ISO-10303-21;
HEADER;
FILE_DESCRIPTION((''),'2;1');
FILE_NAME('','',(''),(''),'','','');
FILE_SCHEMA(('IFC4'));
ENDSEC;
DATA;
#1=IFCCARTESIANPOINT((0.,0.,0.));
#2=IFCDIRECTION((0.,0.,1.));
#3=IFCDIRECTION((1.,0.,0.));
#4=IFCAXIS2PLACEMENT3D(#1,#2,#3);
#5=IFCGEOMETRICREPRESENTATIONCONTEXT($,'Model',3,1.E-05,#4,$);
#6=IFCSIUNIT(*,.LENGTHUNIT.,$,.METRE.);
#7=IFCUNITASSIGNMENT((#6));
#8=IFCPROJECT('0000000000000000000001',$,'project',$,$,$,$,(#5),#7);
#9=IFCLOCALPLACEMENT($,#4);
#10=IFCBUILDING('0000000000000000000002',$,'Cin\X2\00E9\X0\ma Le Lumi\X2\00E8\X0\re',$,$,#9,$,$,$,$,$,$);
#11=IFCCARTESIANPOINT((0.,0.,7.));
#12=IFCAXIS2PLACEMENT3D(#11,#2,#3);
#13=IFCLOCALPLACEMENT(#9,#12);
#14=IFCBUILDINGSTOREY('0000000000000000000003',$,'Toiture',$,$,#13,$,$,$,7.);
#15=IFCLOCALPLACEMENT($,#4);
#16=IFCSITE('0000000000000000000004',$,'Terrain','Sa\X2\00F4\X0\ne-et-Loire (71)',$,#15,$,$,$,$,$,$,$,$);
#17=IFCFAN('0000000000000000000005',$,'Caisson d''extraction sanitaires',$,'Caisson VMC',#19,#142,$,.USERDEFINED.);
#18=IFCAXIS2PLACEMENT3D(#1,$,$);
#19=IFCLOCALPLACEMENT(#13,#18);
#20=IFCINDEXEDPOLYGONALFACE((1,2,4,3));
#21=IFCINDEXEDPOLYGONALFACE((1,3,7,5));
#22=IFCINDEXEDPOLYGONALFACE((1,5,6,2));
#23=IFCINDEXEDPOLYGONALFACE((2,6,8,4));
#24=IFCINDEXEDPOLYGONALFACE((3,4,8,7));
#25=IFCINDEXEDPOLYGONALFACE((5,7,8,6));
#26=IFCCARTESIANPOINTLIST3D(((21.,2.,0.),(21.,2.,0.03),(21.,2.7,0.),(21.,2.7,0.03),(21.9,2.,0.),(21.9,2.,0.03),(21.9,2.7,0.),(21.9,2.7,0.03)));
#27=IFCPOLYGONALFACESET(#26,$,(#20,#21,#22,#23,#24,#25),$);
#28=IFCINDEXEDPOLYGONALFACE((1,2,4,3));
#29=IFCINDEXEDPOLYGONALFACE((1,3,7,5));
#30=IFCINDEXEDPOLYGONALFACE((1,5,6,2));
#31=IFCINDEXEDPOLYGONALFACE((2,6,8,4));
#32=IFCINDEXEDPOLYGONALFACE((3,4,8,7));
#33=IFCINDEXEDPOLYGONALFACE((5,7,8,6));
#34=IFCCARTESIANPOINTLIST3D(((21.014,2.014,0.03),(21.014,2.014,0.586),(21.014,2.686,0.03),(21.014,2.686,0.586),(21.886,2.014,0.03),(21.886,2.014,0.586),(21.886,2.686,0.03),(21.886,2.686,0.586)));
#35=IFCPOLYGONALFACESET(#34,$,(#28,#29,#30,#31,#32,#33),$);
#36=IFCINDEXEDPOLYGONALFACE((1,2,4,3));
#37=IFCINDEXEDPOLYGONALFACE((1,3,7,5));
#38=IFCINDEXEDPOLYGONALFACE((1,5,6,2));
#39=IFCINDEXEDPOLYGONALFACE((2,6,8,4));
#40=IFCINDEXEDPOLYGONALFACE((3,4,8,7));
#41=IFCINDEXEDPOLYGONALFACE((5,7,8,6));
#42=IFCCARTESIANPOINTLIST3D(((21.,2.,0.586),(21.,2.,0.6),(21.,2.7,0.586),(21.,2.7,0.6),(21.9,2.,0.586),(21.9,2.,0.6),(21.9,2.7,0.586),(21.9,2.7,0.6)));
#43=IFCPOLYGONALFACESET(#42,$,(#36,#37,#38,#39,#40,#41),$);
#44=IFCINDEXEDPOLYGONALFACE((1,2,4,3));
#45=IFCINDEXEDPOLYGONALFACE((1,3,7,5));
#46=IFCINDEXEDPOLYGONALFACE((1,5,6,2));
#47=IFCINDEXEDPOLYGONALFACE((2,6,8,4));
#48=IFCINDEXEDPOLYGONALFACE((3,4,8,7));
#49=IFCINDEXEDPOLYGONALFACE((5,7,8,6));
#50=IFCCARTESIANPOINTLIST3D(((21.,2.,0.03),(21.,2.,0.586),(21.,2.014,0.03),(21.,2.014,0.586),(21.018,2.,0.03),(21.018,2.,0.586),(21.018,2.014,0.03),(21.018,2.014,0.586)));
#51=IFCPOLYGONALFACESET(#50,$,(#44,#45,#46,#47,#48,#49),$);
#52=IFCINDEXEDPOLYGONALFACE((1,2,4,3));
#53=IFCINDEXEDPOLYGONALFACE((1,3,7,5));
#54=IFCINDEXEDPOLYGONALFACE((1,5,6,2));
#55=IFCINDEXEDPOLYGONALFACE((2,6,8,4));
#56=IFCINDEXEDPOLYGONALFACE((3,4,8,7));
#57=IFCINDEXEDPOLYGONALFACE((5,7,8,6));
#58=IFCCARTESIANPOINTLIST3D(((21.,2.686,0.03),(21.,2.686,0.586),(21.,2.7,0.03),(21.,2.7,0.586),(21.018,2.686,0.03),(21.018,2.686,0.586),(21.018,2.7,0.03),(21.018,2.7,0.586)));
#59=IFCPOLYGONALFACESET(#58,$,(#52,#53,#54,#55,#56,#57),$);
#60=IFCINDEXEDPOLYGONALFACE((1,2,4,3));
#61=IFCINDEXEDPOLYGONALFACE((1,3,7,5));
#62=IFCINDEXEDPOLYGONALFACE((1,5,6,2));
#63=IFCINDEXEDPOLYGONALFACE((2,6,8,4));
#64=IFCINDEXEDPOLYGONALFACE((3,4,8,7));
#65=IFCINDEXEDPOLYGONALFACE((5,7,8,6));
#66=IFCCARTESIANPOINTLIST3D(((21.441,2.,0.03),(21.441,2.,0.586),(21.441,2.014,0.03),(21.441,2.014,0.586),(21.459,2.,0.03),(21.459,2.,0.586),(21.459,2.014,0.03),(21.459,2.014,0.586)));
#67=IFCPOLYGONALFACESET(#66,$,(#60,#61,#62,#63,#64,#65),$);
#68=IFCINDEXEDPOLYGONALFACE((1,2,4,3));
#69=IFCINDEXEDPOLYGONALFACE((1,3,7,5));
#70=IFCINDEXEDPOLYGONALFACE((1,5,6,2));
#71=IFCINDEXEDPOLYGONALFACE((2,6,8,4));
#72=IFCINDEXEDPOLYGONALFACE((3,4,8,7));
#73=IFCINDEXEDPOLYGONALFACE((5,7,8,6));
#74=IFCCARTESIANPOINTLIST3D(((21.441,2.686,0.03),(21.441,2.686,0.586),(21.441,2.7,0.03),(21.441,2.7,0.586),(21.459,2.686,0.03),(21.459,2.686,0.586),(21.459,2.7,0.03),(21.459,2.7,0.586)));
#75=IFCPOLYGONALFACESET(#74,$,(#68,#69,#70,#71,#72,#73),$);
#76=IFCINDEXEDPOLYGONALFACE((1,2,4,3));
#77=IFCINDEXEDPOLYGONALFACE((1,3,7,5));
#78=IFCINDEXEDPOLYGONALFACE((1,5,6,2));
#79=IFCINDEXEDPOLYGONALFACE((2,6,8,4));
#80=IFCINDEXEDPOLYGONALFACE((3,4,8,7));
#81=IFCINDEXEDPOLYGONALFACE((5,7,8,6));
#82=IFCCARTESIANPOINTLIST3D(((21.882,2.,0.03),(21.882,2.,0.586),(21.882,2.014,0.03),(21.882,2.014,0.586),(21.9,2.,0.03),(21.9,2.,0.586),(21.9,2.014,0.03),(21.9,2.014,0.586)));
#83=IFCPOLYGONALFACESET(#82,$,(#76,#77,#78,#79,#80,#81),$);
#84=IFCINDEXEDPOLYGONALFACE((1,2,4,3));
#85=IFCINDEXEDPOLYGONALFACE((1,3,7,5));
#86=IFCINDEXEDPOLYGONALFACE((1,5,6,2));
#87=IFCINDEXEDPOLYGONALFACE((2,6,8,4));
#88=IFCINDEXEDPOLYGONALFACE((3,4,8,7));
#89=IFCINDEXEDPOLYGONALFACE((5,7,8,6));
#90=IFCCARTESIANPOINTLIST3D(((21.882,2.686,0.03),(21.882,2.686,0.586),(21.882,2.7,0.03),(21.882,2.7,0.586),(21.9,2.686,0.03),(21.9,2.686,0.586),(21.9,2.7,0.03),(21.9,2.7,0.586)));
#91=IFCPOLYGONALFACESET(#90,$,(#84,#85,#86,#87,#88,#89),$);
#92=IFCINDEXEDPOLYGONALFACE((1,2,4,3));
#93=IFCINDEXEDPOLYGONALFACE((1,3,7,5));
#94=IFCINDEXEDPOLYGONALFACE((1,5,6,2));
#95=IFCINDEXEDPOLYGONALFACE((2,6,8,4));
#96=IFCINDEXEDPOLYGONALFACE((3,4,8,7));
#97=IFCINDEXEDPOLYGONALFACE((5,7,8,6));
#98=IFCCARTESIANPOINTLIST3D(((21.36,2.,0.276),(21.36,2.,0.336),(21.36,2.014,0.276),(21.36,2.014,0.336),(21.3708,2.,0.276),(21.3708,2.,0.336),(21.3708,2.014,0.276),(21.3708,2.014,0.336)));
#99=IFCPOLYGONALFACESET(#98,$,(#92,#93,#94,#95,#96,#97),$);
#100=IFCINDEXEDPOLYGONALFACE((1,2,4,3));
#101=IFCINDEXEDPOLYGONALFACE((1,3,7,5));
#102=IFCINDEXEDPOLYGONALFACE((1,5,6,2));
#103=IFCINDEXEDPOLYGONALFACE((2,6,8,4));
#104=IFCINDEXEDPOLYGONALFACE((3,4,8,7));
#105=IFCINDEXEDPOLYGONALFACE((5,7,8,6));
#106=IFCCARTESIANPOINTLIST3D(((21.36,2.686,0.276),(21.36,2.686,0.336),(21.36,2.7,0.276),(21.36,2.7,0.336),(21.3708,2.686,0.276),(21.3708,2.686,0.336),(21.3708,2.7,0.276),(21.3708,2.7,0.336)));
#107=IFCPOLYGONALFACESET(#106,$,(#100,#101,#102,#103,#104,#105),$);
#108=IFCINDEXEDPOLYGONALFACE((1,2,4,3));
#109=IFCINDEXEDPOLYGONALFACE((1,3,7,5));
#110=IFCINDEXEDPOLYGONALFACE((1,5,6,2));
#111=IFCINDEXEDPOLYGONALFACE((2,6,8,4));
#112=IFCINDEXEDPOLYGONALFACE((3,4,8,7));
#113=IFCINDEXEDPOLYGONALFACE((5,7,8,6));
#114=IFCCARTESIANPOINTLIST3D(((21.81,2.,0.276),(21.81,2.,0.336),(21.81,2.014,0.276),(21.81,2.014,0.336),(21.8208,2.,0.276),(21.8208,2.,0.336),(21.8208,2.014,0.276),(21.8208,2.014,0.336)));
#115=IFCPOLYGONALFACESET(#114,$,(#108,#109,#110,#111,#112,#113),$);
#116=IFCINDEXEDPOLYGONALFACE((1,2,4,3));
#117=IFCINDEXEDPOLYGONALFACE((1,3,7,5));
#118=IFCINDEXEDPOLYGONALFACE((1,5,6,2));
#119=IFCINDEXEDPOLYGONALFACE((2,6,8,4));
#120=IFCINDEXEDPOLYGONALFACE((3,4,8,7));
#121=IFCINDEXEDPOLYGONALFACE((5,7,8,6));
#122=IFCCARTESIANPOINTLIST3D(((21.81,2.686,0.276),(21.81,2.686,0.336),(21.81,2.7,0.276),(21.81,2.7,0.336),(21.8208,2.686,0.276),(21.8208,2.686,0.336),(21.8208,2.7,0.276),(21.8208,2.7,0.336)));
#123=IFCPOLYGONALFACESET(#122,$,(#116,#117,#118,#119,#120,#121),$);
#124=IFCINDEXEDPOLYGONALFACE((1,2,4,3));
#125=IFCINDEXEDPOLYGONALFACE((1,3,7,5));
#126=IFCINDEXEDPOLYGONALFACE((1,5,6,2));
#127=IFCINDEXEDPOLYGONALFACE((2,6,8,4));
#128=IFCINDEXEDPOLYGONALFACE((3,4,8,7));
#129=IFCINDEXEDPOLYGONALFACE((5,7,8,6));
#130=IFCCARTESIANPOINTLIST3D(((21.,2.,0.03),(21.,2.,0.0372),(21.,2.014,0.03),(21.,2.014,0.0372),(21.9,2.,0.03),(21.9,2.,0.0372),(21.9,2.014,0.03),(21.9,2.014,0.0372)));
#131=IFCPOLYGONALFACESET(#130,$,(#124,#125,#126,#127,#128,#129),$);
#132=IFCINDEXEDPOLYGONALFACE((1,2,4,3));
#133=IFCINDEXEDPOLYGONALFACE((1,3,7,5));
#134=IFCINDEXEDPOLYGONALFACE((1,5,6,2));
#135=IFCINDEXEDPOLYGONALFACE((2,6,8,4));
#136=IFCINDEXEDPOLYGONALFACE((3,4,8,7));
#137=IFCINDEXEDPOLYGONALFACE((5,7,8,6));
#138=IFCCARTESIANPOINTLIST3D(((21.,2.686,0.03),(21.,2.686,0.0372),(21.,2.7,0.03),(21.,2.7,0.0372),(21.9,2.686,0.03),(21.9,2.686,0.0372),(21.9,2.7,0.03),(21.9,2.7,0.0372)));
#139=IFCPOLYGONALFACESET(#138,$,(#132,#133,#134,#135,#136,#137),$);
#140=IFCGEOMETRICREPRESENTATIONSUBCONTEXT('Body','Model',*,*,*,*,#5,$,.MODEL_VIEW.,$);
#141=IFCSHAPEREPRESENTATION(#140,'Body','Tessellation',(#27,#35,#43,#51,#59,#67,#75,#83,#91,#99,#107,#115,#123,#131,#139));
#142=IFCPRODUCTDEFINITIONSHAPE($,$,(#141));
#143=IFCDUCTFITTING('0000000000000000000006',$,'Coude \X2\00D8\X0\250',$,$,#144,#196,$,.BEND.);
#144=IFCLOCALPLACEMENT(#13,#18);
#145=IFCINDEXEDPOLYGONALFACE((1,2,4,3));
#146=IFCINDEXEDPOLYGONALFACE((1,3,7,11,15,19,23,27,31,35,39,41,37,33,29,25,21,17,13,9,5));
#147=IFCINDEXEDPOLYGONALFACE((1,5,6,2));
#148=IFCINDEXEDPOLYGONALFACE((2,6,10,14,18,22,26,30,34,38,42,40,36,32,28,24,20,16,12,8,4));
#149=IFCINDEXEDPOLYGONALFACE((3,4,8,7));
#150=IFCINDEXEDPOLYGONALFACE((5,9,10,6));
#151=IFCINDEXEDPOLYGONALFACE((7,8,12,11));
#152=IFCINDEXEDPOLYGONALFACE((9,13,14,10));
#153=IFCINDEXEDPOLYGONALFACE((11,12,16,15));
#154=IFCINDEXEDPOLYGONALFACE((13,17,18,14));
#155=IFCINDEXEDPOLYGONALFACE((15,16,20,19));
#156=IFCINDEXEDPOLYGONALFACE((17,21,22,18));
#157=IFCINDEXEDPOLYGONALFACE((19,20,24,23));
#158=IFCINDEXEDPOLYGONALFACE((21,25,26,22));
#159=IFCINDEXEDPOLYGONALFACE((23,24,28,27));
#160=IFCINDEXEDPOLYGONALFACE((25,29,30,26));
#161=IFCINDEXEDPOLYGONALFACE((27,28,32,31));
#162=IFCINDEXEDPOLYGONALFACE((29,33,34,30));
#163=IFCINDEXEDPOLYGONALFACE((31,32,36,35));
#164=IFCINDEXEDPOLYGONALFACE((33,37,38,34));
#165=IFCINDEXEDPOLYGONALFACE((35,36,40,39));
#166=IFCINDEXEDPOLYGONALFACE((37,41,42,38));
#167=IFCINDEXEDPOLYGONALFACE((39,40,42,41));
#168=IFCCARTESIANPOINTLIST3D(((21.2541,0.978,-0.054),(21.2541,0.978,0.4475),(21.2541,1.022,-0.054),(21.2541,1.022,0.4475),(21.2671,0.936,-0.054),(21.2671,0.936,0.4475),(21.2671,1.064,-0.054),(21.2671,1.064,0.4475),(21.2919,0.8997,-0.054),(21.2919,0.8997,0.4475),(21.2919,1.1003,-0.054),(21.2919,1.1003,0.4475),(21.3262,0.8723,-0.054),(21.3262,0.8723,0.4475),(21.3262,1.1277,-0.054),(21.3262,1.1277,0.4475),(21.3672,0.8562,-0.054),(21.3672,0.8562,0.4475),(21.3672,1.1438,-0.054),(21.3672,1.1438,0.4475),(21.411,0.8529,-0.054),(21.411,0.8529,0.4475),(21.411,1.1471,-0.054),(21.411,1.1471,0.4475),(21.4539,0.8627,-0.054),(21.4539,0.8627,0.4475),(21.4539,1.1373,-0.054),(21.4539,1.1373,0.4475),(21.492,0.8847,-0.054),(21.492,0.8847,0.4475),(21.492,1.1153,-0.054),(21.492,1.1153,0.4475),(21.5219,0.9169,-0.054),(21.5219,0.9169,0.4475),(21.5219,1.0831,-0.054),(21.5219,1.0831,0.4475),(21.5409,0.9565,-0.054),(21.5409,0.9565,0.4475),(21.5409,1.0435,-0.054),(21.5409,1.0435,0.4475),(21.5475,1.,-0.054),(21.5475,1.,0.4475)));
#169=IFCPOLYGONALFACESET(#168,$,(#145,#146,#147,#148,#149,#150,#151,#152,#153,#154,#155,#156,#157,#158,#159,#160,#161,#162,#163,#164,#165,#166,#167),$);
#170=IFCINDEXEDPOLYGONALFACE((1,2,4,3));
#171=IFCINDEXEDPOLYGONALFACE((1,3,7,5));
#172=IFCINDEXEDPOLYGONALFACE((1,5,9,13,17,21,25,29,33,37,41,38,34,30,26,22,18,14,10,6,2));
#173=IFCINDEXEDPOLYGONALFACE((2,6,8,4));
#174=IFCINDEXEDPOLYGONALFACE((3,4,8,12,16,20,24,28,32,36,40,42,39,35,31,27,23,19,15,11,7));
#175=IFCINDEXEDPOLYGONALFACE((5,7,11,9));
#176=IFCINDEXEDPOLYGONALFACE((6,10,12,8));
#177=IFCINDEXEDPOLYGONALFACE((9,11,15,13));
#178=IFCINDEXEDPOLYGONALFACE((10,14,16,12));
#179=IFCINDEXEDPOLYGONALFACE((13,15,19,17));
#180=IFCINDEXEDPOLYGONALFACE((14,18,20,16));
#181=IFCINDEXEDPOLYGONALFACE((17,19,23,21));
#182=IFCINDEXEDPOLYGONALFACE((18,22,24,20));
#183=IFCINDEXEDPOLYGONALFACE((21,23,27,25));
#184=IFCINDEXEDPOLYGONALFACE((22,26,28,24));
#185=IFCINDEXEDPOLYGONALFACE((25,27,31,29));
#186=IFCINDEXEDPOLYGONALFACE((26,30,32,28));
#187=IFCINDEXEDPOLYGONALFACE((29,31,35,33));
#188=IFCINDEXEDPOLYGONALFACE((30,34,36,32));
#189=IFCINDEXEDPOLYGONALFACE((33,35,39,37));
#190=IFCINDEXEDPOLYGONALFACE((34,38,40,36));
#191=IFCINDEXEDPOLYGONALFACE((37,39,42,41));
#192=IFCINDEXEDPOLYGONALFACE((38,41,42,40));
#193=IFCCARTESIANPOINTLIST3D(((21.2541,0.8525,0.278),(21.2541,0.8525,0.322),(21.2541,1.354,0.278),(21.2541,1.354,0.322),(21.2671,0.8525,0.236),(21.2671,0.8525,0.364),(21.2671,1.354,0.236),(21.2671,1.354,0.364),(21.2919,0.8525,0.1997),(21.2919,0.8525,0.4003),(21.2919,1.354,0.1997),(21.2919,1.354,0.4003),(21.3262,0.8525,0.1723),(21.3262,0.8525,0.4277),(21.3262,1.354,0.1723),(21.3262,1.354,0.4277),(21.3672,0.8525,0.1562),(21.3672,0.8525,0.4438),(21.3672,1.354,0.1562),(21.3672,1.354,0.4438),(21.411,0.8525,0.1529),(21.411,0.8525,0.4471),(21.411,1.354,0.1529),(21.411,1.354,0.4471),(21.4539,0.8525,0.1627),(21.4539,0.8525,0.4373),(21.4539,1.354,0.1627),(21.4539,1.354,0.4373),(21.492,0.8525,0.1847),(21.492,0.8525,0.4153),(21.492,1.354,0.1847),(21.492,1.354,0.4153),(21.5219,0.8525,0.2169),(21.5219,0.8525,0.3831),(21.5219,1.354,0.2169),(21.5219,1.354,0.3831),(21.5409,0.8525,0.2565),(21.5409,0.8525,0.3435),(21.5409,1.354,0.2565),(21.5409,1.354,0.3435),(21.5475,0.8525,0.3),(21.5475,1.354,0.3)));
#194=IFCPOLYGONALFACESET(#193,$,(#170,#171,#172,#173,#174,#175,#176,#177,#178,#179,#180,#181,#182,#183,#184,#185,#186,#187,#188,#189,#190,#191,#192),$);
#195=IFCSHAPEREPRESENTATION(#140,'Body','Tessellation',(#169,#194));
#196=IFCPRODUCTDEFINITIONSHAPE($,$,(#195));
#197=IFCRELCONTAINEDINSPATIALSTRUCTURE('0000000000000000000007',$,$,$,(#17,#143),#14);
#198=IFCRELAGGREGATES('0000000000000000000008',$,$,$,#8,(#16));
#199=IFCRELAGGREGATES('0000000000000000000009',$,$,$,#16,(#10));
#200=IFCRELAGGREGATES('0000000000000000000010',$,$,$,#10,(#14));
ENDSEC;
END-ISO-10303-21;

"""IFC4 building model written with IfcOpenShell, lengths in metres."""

from ifc_helpers import new_model, si_unit, frame, frame_2d, origin_with_axes, place, context, subcontext, project, spatial, rectangle, circle, extrude, element, save


model = new_model("IFC4")

# Units and contexts
model_context = context("Model", 3, precision=1e-05, world=origin_with_axes())
body_context = subcontext(model_context, "Body", "Model", "MODEL_VIEW")
ifc_project = project(units=[si_unit("LENGTHUNIT", "METRE")], contexts=[model_context])

# Site, building, storey
site_placement = place(None, origin_with_axes())
site = spatial("IfcSite", under=ifc_project, at=site_placement, Name="Terrain", Description="Saône-et-Loire (71)")
building_placement = place(None, origin_with_axes())
building = spatial("IfcBuilding", under=site, at=building_placement, Name="Cinéma Le Lumière")
storey_placement = place(building_placement, frame((0.0, 0.0, 7.0), z_axis=(0.0, 0.0, 1.0), x_axis=(1.0, 0.0, 0.0)))
storey = spatial("IfcBuildingStorey", under=building, at=storey_placement, Name="Toiture", Elevation=7.0)

# Fan
fan_placement = place(storey_placement, frame((21.0, 2.0, 0.0), z_axis=(0.0, 0.0, 1.0), x_axis=(1.0, 0.0, 0.0)))
element("IfcFan", 1, at=fan_placement, inside=storey, Name="Caisson d'extraction sanitaires", ObjectType="Caisson VMC", PredefinedType="USERDEFINED", context=body_context, shape_type="SweptSolid", body=[
    extrude(rectangle(XDim=0.9, YDim=0.7, at=frame_2d((0.45, 0.35))), origin_with_axes(), (0.0, 0.0, 1.0), 0.03),
    extrude(rectangle(XDim=0.872, YDim=0.672, at=frame_2d((0.436, 0.336))), frame((0.014, 0.014, 0.03), z_axis=(0.0, 0.0, 1.0), x_axis=(1.0, 0.0, 0.0)), (0.0, 0.0, 1.0), 0.556),
    extrude(rectangle(XDim=0.9, YDim=0.7, at=frame_2d((0.45, 0.35))), frame((0.0, 0.0, 0.586), z_axis=(0.0, 0.0, 1.0), x_axis=(1.0, 0.0, 0.0)), (0.0, 0.0, 1.0), 0.014),
    extrude(rectangle(XDim=0.018, YDim=0.014, at=frame_2d((0.009, 0.007))), frame((0.0, 0.0, 0.03), z_axis=(0.0, 0.0, 1.0), x_axis=(1.0, 0.0, 0.0)), (0.0, 0.0, 1.0), 0.556),
    extrude(rectangle(XDim=0.018, YDim=0.014, at=frame_2d((0.009, 0.007))), frame((0.0, 0.686, 0.03), z_axis=(0.0, 0.0, 1.0), x_axis=(1.0, 0.0, 0.0)), (0.0, 0.0, 1.0), 0.556),
    extrude(rectangle(XDim=0.018, YDim=0.014, at=frame_2d((0.009, 0.007))), frame((0.441, 0.0, 0.03), z_axis=(0.0, 0.0, 1.0), x_axis=(1.0, 0.0, 0.0)), (0.0, 0.0, 1.0), 0.556),
    extrude(rectangle(XDim=0.018, YDim=0.014, at=frame_2d((0.009, 0.007))), frame((0.441, 0.686, 0.03), z_axis=(0.0, 0.0, 1.0), x_axis=(1.0, 0.0, 0.0)), (0.0, 0.0, 1.0), 0.556),
    extrude(rectangle(XDim=0.018, YDim=0.014, at=frame_2d((0.009, 0.007))), frame((0.882, 0.0, 0.03), z_axis=(0.0, 0.0, 1.0), x_axis=(1.0, 0.0, 0.0)), (0.0, 0.0, 1.0), 0.556),
    extrude(rectangle(XDim=0.018, YDim=0.014, at=frame_2d((0.009, 0.007))), frame((0.882, 0.686, 0.03), z_axis=(0.0, 0.0, 1.0), x_axis=(1.0, 0.0, 0.0)), (0.0, 0.0, 1.0), 0.556),
    extrude(rectangle(XDim=0.0108, YDim=0.014, at=frame_2d((0.0054, 0.007))), frame((0.36, 0.0, 0.276), z_axis=(0.0, 0.0, 1.0), x_axis=(1.0, 0.0, 0.0)), (0.0, 0.0, 1.0), 0.06),
    extrude(rectangle(XDim=0.0108, YDim=0.014, at=frame_2d((0.0054, 0.007))), frame((0.36, 0.686, 0.276), z_axis=(0.0, 0.0, 1.0), x_axis=(1.0, 0.0, 0.0)), (0.0, 0.0, 1.0), 0.06),
    extrude(rectangle(XDim=0.0108, YDim=0.014, at=frame_2d((0.0054, 0.007))), frame((0.81, 0.0, 0.276), z_axis=(0.0, 0.0, 1.0), x_axis=(1.0, 0.0, 0.0)), (0.0, 0.0, 1.0), 0.06),
    extrude(rectangle(XDim=0.0108, YDim=0.014, at=frame_2d((0.0054, 0.007))), frame((0.81, 0.686, 0.276), z_axis=(0.0, 0.0, 1.0), x_axis=(1.0, 0.0, 0.0)), (0.0, 0.0, 1.0), 0.06),
    extrude(rectangle(XDim=0.9, YDim=0.014, at=frame_2d((0.45, 0.007))), frame((0.0, 0.0, 0.03), z_axis=(0.0, 0.0, 1.0), x_axis=(1.0, 0.0, 0.0)), (0.0, 0.0, 1.0), 0.0072),
    extrude(rectangle(XDim=0.9, YDim=0.014, at=frame_2d((0.45, 0.007))), frame((0.0, 0.686, 0.03), z_axis=(0.0, 0.0, 1.0), x_axis=(1.0, 0.0, 0.0)), (0.0, 0.0, 1.0), 0.0072),
])

# Duct fitting
duct_fitting_placement = place(storey_placement, frame((21.4, 1.0, 0.3), z_axis=(0.0, 0.0, 1.0), x_axis=(1.0, 0.0, 0.0)))
element("IfcDuctFitting", 2, at=duct_fitting_placement, inside=storey, Name="Coude Ø250", PredefinedType="BEND", context=body_context, shape_type="SweptSolid", body=[
    extrude(circle(Radius=0.1475), frame((0.0, 0.0, 0.1475), z_axis=(0.0, 0.0, -1.0), x_axis=(1.0, 0.0, 0.0)), (0.0, 0.0, 1.0), 0.5015),
    extrude(circle(Radius=0.1475), frame((0.0, -0.1475, 0.0), z_axis=(0.0, 1.0, 0.0), x_axis=(1.0, 0.0, 0.0)), (0.0, 0.0, 1.0), 0.5015),
])

save(model, "model.ifc")
